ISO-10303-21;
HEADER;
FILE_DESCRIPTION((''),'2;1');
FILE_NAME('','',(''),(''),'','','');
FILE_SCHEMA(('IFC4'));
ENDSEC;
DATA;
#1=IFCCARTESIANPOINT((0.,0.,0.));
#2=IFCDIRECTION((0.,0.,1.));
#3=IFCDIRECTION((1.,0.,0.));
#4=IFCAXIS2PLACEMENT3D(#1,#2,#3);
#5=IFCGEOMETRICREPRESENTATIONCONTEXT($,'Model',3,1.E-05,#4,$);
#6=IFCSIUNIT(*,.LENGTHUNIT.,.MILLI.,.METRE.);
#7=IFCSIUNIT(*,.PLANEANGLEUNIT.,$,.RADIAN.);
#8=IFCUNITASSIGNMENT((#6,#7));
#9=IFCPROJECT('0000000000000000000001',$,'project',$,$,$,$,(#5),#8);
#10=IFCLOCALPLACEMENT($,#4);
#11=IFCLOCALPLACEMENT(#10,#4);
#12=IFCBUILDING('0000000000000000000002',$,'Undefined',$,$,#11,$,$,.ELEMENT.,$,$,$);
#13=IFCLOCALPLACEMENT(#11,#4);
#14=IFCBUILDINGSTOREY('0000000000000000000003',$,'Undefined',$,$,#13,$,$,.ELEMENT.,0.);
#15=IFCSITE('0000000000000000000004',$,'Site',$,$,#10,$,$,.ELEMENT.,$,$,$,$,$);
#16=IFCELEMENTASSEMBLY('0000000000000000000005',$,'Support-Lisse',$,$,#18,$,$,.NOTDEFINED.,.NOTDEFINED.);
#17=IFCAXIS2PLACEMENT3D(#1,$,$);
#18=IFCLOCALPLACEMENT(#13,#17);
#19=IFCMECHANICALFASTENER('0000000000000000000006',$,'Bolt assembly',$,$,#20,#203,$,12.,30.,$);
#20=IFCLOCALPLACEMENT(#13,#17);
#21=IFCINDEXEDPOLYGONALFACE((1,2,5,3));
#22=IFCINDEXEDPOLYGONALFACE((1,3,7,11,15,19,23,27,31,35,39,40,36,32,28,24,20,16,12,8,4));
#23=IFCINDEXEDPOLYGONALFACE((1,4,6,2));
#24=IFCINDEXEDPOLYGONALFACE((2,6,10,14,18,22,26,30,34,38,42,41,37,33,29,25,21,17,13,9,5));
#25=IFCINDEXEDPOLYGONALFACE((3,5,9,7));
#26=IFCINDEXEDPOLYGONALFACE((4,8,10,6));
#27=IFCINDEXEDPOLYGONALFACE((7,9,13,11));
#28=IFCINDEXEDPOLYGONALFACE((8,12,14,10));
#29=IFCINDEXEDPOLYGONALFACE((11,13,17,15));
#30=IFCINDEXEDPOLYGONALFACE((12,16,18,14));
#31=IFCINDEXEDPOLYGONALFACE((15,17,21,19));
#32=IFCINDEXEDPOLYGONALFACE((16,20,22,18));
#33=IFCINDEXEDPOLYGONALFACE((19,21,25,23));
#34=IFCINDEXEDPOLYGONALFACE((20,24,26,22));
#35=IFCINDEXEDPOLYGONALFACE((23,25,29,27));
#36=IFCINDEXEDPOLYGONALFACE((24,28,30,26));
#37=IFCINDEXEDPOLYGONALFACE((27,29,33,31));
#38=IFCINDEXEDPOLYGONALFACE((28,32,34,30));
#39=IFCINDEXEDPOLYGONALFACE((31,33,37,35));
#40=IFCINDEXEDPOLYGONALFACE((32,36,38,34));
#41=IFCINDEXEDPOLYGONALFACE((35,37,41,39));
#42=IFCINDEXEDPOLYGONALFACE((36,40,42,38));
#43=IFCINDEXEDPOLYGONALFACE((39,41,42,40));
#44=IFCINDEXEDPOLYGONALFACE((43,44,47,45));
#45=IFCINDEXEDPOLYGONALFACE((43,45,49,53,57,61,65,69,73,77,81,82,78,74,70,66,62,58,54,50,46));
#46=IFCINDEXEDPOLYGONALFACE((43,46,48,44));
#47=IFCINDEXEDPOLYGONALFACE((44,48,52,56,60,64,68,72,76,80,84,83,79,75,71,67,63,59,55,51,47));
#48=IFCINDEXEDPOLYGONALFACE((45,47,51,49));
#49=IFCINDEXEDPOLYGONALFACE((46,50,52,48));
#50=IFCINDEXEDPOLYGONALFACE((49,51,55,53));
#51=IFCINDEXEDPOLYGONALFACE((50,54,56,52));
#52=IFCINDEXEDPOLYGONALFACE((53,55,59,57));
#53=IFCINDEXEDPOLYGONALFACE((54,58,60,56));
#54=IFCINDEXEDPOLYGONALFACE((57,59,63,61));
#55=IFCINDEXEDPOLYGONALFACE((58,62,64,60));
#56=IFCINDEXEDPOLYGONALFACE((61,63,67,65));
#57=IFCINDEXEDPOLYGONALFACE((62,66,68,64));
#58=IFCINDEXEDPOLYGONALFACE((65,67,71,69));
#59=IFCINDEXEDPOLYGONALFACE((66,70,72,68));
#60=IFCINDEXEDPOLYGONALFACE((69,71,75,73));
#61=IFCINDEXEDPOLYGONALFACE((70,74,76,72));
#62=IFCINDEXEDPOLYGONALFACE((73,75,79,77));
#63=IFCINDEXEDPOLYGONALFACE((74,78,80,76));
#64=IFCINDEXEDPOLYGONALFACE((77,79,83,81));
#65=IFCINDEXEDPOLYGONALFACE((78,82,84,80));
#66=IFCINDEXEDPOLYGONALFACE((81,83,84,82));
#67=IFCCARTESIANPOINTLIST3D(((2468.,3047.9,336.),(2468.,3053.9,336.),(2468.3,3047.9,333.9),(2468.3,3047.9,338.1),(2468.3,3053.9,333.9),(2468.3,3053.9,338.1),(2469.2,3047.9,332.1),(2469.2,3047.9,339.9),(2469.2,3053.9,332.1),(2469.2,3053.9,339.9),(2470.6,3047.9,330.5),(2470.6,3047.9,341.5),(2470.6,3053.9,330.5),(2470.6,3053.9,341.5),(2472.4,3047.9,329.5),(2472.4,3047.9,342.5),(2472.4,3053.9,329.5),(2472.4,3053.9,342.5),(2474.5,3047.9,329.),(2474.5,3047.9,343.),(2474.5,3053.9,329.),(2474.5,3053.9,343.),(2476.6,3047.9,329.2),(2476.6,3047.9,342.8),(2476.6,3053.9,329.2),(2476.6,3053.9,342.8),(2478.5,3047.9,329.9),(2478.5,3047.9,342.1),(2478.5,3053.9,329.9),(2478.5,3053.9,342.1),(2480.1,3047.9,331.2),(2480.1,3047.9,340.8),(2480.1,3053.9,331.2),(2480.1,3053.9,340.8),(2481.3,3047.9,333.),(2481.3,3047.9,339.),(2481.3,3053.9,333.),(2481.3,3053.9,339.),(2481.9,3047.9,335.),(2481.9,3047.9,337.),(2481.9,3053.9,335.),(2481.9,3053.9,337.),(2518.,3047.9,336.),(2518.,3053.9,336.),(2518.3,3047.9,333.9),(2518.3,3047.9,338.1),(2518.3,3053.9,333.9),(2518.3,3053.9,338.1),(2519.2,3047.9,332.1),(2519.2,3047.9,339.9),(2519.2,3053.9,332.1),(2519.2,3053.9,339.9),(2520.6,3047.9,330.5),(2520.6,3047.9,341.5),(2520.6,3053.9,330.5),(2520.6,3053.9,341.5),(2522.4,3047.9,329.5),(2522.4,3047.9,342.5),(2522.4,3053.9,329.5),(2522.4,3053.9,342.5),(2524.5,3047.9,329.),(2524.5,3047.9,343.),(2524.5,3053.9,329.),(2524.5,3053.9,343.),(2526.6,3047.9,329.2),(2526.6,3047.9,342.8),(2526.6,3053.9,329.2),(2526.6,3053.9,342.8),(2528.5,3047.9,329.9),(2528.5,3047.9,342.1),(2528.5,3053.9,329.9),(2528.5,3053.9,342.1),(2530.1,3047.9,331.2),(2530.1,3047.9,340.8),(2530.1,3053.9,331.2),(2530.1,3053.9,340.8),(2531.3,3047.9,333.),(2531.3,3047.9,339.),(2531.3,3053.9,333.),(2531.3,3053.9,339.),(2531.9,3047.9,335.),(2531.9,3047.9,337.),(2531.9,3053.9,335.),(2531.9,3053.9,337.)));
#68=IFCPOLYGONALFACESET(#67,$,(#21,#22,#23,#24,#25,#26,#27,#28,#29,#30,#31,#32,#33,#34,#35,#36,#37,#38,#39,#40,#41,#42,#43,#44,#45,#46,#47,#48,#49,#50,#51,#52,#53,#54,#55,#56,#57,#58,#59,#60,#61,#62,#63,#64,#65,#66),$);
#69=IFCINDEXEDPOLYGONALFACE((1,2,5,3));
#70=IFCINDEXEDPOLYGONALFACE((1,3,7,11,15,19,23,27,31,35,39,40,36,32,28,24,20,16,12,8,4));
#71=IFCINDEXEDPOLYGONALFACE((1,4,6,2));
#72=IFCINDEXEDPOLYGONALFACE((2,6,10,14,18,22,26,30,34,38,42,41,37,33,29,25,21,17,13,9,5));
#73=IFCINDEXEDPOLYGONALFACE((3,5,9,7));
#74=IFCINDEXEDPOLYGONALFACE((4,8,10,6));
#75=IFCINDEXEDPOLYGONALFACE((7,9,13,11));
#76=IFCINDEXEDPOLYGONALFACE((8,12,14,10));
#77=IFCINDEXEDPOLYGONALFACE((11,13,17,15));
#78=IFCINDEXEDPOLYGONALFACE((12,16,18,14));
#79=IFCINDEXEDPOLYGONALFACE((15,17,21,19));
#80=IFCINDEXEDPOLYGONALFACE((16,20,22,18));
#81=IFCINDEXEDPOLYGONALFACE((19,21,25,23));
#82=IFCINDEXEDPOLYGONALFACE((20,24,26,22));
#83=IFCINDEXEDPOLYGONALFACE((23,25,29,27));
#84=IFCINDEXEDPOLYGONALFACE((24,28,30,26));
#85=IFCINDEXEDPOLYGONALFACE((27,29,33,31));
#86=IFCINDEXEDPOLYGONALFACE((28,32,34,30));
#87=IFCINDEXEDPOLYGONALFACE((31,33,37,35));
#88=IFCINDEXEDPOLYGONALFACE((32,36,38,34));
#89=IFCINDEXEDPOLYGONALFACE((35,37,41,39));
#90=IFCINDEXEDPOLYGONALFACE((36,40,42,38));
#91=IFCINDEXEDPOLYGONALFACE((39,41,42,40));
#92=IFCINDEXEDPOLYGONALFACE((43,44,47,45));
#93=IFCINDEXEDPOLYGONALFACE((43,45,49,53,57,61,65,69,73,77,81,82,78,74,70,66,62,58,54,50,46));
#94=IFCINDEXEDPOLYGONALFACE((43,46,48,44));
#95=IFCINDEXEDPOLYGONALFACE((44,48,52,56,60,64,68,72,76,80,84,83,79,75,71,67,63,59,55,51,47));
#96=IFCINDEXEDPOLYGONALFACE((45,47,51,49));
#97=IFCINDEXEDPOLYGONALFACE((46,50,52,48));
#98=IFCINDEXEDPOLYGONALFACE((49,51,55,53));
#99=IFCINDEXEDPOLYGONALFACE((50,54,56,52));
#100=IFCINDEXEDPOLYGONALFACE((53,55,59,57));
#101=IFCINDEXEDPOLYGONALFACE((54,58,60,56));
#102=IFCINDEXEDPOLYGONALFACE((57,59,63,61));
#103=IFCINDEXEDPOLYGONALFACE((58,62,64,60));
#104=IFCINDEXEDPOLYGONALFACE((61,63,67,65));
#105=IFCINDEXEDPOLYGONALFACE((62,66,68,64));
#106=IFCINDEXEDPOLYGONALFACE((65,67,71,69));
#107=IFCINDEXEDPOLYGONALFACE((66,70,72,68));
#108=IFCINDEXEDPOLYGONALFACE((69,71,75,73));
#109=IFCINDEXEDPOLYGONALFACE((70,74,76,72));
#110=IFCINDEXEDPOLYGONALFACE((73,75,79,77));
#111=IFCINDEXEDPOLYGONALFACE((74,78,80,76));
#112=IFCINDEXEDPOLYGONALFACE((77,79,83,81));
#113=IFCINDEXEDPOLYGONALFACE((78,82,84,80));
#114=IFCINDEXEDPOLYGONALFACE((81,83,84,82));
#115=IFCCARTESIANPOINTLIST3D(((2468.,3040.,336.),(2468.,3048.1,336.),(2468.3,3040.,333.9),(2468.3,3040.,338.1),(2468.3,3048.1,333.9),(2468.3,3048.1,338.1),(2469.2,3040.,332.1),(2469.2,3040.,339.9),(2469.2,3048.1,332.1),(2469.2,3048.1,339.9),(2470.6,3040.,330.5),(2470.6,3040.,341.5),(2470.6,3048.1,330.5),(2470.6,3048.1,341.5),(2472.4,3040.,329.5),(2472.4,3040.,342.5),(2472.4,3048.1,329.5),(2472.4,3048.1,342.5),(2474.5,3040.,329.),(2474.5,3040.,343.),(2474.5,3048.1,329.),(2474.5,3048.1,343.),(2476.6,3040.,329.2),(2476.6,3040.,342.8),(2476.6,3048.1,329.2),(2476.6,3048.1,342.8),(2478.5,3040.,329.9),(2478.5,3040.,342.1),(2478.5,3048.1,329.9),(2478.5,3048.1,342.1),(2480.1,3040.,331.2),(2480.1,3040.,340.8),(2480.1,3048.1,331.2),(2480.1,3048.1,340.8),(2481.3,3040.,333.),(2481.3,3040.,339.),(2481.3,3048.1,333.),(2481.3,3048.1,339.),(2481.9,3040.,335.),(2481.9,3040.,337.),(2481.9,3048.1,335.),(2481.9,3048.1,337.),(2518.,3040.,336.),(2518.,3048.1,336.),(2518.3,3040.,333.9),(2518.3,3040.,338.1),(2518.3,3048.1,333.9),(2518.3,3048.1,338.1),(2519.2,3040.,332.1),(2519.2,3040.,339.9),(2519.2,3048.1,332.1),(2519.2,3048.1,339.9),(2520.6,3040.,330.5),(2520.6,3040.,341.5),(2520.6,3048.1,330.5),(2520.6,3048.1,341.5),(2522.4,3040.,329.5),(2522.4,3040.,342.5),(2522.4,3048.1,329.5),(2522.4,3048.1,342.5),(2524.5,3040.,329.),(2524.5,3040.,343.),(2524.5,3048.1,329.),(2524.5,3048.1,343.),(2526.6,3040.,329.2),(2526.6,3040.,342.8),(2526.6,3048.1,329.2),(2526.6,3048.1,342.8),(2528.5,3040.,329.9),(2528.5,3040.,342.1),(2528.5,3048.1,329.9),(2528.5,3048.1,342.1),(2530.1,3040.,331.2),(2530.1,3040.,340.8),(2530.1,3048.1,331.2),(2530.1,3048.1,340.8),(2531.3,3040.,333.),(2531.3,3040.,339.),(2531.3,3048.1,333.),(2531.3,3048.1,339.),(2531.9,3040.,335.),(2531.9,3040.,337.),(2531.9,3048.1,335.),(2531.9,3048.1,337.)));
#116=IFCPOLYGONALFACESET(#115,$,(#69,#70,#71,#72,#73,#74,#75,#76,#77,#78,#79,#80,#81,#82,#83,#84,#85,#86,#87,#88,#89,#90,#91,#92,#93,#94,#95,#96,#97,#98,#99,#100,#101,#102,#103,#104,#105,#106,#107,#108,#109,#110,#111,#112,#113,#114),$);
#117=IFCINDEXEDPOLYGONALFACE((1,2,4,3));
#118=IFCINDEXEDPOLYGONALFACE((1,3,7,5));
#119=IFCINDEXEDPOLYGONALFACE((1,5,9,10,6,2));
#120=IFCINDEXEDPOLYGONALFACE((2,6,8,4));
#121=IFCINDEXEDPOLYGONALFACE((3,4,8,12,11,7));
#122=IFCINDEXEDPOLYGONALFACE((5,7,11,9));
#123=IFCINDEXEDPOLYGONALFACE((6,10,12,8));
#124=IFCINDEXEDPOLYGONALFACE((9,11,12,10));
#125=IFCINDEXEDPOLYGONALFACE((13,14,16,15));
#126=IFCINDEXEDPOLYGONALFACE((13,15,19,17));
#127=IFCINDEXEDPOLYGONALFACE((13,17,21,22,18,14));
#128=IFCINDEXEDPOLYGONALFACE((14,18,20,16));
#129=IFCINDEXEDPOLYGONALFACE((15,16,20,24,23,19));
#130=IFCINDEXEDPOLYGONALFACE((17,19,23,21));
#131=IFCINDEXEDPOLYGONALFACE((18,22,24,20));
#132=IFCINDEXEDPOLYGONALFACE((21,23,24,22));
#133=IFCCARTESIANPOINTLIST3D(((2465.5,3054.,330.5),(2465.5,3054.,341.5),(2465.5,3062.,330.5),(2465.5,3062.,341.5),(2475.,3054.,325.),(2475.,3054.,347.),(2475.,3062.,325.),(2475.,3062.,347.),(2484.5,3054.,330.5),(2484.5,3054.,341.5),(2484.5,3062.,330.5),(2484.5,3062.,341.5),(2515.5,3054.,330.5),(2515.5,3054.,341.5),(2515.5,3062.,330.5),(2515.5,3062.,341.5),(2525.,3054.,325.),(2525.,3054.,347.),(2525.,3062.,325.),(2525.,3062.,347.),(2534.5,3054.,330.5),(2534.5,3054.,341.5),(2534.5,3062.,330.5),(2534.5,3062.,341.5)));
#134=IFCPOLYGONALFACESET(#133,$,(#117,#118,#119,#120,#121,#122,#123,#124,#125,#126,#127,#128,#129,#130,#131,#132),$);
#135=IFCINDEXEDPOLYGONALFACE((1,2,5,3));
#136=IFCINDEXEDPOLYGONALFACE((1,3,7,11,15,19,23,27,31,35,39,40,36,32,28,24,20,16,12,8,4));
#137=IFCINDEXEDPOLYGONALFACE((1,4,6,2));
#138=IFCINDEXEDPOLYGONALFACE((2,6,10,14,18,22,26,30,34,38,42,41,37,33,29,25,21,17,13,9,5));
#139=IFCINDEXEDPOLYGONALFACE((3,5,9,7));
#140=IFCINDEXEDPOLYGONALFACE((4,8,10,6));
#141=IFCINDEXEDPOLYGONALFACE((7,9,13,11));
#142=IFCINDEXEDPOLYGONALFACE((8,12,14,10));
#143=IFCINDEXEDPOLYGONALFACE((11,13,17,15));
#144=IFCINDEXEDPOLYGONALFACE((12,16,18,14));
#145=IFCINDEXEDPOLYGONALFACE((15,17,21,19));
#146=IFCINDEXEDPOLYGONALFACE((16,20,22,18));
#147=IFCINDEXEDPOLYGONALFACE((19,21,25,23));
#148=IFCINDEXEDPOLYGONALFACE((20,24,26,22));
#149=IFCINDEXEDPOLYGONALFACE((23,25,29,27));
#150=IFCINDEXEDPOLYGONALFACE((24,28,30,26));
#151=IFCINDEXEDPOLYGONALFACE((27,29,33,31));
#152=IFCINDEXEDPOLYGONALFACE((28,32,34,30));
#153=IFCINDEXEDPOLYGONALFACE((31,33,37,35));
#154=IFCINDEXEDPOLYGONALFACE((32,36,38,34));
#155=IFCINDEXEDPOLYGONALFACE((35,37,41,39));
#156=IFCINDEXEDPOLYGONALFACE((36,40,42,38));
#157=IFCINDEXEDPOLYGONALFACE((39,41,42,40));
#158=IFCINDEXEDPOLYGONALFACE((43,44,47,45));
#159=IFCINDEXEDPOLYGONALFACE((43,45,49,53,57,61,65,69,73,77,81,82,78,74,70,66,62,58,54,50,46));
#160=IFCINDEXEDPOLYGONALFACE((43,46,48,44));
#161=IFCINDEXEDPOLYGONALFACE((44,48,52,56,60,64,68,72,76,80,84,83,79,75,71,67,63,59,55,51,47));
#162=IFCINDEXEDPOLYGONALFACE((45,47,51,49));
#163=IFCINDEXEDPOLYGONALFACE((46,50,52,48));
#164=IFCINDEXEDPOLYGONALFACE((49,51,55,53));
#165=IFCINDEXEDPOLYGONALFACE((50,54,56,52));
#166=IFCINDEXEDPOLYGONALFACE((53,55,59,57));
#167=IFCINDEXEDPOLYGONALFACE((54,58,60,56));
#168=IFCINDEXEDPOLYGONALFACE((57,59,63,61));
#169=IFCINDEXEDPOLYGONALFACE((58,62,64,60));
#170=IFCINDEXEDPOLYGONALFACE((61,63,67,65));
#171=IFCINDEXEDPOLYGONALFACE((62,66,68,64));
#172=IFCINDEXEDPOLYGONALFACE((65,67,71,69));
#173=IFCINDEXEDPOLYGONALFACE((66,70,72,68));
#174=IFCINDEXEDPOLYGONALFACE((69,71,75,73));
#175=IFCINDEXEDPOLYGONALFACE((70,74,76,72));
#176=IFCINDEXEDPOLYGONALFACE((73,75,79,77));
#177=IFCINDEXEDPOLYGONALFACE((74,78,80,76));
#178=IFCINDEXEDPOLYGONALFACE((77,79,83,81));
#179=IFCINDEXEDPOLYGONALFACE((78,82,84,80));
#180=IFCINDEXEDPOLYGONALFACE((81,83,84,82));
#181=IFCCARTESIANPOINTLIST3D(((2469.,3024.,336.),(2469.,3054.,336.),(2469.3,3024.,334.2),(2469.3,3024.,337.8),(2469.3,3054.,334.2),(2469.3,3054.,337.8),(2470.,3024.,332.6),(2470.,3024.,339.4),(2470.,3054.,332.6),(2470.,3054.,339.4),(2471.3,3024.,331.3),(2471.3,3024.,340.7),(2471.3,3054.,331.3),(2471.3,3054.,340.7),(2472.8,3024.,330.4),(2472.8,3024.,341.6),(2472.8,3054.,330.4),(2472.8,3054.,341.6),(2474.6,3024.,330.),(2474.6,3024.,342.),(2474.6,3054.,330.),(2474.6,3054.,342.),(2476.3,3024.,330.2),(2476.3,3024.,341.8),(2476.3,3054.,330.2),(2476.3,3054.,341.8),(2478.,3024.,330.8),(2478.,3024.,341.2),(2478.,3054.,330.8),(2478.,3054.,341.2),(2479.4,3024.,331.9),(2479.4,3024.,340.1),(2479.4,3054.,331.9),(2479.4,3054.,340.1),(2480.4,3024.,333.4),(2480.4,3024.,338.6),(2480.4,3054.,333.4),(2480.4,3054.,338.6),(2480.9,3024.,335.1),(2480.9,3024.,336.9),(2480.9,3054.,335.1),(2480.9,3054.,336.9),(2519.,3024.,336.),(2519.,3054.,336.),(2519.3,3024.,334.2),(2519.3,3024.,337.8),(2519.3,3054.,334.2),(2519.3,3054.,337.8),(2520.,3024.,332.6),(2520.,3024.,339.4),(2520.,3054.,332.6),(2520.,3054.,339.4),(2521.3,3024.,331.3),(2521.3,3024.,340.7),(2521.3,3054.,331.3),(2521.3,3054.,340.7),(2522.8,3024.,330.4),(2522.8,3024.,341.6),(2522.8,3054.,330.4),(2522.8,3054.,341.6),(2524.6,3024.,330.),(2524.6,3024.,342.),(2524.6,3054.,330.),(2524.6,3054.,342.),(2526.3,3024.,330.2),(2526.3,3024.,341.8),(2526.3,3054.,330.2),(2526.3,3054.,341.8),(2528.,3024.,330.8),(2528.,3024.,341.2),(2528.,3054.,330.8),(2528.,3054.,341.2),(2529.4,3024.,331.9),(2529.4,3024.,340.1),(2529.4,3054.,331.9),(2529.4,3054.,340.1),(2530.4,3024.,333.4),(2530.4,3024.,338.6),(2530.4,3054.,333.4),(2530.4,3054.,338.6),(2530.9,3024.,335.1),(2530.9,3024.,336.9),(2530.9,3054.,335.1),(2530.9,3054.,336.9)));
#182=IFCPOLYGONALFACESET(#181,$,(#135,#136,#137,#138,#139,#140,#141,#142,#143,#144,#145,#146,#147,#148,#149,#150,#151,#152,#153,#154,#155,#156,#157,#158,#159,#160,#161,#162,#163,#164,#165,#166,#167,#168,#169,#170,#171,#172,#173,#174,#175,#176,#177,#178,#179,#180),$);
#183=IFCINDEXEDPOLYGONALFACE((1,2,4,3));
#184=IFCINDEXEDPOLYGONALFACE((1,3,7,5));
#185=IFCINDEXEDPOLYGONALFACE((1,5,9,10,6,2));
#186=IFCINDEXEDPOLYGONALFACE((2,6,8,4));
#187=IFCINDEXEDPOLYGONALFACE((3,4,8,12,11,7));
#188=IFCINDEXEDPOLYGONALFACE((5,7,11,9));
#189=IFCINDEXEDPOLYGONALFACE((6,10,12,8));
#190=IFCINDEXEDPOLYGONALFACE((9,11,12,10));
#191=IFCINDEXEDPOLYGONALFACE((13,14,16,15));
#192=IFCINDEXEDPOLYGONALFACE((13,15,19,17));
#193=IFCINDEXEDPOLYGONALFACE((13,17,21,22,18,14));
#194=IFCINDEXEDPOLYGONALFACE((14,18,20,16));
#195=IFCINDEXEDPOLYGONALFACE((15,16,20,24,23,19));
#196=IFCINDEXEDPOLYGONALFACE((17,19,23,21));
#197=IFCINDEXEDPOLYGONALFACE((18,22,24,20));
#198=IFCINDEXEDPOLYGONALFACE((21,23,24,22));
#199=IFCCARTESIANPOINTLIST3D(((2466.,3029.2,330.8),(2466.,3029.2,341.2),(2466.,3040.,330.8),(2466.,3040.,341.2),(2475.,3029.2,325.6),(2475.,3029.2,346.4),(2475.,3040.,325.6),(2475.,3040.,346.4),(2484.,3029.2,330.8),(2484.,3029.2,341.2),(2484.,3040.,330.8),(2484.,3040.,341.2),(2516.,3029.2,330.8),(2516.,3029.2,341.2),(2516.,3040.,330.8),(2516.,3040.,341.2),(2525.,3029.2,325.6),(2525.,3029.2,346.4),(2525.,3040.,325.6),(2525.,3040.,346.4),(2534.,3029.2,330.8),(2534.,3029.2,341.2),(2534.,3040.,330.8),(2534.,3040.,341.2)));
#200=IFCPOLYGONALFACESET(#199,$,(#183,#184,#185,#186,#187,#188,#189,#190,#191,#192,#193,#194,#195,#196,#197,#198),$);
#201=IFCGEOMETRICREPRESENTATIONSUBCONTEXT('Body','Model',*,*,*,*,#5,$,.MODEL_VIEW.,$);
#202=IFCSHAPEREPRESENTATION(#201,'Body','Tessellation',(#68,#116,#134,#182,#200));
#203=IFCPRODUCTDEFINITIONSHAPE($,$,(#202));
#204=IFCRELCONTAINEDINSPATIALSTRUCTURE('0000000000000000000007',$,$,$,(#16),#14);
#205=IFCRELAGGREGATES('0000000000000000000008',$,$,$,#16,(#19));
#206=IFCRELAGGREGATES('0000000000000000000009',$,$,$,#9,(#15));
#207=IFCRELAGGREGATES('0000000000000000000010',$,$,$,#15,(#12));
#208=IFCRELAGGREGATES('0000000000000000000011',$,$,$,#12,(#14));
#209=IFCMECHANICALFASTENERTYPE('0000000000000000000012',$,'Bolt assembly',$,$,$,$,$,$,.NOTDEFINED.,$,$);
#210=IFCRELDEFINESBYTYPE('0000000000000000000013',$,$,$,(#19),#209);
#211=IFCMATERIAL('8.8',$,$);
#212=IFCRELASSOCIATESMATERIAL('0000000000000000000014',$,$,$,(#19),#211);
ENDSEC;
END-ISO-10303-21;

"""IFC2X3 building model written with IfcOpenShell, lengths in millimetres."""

from ifc_helpers import new_model, si_unit, frame, origin_with_axes, origin_2d_with_axis, place, context, subcontext, project, spatial, polyline, circle, outline, extrude, source, transform, mapped, material, type_object, element, aggregate, save


model = new_model("IFC2X3")

# Units and contexts
model_context = context("Model", 3, precision=1e-05, world=origin_with_axes())
body_context = subcontext(model_context, "Body", "Model", "MODEL_VIEW")
ifc_project = project(units=[si_unit("LENGTHUNIT", "METRE", prefix="MILLI"), si_unit("PLANEANGLEUNIT", "RADIAN")], contexts=[model_context])

# Site, building, storey
site_placement = place(None, origin_with_axes())
site = spatial("IfcSite", under=ifc_project, at=site_placement, Name="Site", CompositionType="ELEMENT")
building_placement = place(site_placement, origin_with_axes())
building = spatial("IfcBuilding", under=site, at=building_placement, Name="Undefined", CompositionType="ELEMENT")
storey_placement = place(building_placement, origin_with_axes())
storey = spatial("IfcBuildingStorey", under=building, at=storey_placement, Name="Undefined", CompositionType="ELEMENT", Elevation=0.0)

# Shared definitions
mechanical_fastener_type = type_object("IfcMechanicalFastenerType", Name="Bolt assembly")
ifc_material_1 = material(Name="8.8")

# Element assembly, mechanical fastener
assembly_1_placement = place(storey_placement, origin_with_axes())
assembly_1 = element("IfcElementAssembly", 1, at=assembly_1_placement, inside=storey, Name="Support-Lisse", AssemblyPlace="NOTDEFINED", PredefinedType="NOTDEFINED")
shared_shape_1 = source(origin_with_axes(), body_context, "Body", "SweptSolid", [
    extrude(circle(Radius=7.0, at=origin_2d_with_axis()), frame((0.0, -5.9, 0.0), z_axis=(0.0, 1.0, 0.0), x_axis=(1.0, 0.0, 0.0)), (0.0, 0.0, 1.0), 6.0),
    extrude(circle(Radius=7.0, at=origin_2d_with_axis()), frame((0.0, -0.1, 0.0), z_axis=(0.0, 1.0, 0.0), x_axis=(1.0, 0.0, 0.0)), (0.0, 0.0, 1.0), 8.1),
    extrude(outline(polyline([(9.5, -5.5), (9.5, 5.5), (0.0, 11.0), (-9.5, 5.5), (-9.5, -5.5), (0.0, -11.0), (9.5, -5.5)])), frame((0.0, -14.0, 0.0), z_axis=(0.0, 1.0, 0.0), x_axis=(1.0, 0.0, 0.0)), (0.0, 0.0, 1.0), 8.0),
    extrude(circle(Radius=6.0, at=origin_2d_with_axis()), frame((0.0, -6.0, 0.0), z_axis=(0.0, 1.0, 0.0), x_axis=(1.0, 0.0, 0.0)), (0.0, 0.0, 1.0), 30.0),
    extrude(outline(polyline([(9.0, -5.2), (9.0, 5.2), (0.0, 10.4), (-9.0, 5.2), (-9.0, -5.2), (0.0, -10.4), (9.0, -5.2)])), frame((0.0, 8.0, 0.0), z_axis=(0.0, 1.0, 0.0), x_axis=(1.0, 0.0, 0.0)), (0.0, 0.0, 1.0), 10.8),
])
mechanical_fastener_1_placement = place(assembly_1_placement, frame((2525.0, 3048.0, 336.0), z_axis=(0.0, 0.0, 1.0), x_axis=(-1.0, 0.0, 0.0)))
mechanical_fastener_1 = element("IfcMechanicalFastener", 2, at=mechanical_fastener_1_placement, type_object=mechanical_fastener_type, material=ifc_material_1, Name="Bolt assembly", NominalDiameter=12.0, NominalLength=30.0, context=body_context, shape_type="MappedRepresentation", body=[
    mapped(shared_shape_1, transform((0.0, 0.0, 0.0))),
    mapped(shared_shape_1, transform((50.0, 0.0, 0.0))),
])
aggregate(assembly_1, [mechanical_fastener_1])

save(model, "model.ifc")
